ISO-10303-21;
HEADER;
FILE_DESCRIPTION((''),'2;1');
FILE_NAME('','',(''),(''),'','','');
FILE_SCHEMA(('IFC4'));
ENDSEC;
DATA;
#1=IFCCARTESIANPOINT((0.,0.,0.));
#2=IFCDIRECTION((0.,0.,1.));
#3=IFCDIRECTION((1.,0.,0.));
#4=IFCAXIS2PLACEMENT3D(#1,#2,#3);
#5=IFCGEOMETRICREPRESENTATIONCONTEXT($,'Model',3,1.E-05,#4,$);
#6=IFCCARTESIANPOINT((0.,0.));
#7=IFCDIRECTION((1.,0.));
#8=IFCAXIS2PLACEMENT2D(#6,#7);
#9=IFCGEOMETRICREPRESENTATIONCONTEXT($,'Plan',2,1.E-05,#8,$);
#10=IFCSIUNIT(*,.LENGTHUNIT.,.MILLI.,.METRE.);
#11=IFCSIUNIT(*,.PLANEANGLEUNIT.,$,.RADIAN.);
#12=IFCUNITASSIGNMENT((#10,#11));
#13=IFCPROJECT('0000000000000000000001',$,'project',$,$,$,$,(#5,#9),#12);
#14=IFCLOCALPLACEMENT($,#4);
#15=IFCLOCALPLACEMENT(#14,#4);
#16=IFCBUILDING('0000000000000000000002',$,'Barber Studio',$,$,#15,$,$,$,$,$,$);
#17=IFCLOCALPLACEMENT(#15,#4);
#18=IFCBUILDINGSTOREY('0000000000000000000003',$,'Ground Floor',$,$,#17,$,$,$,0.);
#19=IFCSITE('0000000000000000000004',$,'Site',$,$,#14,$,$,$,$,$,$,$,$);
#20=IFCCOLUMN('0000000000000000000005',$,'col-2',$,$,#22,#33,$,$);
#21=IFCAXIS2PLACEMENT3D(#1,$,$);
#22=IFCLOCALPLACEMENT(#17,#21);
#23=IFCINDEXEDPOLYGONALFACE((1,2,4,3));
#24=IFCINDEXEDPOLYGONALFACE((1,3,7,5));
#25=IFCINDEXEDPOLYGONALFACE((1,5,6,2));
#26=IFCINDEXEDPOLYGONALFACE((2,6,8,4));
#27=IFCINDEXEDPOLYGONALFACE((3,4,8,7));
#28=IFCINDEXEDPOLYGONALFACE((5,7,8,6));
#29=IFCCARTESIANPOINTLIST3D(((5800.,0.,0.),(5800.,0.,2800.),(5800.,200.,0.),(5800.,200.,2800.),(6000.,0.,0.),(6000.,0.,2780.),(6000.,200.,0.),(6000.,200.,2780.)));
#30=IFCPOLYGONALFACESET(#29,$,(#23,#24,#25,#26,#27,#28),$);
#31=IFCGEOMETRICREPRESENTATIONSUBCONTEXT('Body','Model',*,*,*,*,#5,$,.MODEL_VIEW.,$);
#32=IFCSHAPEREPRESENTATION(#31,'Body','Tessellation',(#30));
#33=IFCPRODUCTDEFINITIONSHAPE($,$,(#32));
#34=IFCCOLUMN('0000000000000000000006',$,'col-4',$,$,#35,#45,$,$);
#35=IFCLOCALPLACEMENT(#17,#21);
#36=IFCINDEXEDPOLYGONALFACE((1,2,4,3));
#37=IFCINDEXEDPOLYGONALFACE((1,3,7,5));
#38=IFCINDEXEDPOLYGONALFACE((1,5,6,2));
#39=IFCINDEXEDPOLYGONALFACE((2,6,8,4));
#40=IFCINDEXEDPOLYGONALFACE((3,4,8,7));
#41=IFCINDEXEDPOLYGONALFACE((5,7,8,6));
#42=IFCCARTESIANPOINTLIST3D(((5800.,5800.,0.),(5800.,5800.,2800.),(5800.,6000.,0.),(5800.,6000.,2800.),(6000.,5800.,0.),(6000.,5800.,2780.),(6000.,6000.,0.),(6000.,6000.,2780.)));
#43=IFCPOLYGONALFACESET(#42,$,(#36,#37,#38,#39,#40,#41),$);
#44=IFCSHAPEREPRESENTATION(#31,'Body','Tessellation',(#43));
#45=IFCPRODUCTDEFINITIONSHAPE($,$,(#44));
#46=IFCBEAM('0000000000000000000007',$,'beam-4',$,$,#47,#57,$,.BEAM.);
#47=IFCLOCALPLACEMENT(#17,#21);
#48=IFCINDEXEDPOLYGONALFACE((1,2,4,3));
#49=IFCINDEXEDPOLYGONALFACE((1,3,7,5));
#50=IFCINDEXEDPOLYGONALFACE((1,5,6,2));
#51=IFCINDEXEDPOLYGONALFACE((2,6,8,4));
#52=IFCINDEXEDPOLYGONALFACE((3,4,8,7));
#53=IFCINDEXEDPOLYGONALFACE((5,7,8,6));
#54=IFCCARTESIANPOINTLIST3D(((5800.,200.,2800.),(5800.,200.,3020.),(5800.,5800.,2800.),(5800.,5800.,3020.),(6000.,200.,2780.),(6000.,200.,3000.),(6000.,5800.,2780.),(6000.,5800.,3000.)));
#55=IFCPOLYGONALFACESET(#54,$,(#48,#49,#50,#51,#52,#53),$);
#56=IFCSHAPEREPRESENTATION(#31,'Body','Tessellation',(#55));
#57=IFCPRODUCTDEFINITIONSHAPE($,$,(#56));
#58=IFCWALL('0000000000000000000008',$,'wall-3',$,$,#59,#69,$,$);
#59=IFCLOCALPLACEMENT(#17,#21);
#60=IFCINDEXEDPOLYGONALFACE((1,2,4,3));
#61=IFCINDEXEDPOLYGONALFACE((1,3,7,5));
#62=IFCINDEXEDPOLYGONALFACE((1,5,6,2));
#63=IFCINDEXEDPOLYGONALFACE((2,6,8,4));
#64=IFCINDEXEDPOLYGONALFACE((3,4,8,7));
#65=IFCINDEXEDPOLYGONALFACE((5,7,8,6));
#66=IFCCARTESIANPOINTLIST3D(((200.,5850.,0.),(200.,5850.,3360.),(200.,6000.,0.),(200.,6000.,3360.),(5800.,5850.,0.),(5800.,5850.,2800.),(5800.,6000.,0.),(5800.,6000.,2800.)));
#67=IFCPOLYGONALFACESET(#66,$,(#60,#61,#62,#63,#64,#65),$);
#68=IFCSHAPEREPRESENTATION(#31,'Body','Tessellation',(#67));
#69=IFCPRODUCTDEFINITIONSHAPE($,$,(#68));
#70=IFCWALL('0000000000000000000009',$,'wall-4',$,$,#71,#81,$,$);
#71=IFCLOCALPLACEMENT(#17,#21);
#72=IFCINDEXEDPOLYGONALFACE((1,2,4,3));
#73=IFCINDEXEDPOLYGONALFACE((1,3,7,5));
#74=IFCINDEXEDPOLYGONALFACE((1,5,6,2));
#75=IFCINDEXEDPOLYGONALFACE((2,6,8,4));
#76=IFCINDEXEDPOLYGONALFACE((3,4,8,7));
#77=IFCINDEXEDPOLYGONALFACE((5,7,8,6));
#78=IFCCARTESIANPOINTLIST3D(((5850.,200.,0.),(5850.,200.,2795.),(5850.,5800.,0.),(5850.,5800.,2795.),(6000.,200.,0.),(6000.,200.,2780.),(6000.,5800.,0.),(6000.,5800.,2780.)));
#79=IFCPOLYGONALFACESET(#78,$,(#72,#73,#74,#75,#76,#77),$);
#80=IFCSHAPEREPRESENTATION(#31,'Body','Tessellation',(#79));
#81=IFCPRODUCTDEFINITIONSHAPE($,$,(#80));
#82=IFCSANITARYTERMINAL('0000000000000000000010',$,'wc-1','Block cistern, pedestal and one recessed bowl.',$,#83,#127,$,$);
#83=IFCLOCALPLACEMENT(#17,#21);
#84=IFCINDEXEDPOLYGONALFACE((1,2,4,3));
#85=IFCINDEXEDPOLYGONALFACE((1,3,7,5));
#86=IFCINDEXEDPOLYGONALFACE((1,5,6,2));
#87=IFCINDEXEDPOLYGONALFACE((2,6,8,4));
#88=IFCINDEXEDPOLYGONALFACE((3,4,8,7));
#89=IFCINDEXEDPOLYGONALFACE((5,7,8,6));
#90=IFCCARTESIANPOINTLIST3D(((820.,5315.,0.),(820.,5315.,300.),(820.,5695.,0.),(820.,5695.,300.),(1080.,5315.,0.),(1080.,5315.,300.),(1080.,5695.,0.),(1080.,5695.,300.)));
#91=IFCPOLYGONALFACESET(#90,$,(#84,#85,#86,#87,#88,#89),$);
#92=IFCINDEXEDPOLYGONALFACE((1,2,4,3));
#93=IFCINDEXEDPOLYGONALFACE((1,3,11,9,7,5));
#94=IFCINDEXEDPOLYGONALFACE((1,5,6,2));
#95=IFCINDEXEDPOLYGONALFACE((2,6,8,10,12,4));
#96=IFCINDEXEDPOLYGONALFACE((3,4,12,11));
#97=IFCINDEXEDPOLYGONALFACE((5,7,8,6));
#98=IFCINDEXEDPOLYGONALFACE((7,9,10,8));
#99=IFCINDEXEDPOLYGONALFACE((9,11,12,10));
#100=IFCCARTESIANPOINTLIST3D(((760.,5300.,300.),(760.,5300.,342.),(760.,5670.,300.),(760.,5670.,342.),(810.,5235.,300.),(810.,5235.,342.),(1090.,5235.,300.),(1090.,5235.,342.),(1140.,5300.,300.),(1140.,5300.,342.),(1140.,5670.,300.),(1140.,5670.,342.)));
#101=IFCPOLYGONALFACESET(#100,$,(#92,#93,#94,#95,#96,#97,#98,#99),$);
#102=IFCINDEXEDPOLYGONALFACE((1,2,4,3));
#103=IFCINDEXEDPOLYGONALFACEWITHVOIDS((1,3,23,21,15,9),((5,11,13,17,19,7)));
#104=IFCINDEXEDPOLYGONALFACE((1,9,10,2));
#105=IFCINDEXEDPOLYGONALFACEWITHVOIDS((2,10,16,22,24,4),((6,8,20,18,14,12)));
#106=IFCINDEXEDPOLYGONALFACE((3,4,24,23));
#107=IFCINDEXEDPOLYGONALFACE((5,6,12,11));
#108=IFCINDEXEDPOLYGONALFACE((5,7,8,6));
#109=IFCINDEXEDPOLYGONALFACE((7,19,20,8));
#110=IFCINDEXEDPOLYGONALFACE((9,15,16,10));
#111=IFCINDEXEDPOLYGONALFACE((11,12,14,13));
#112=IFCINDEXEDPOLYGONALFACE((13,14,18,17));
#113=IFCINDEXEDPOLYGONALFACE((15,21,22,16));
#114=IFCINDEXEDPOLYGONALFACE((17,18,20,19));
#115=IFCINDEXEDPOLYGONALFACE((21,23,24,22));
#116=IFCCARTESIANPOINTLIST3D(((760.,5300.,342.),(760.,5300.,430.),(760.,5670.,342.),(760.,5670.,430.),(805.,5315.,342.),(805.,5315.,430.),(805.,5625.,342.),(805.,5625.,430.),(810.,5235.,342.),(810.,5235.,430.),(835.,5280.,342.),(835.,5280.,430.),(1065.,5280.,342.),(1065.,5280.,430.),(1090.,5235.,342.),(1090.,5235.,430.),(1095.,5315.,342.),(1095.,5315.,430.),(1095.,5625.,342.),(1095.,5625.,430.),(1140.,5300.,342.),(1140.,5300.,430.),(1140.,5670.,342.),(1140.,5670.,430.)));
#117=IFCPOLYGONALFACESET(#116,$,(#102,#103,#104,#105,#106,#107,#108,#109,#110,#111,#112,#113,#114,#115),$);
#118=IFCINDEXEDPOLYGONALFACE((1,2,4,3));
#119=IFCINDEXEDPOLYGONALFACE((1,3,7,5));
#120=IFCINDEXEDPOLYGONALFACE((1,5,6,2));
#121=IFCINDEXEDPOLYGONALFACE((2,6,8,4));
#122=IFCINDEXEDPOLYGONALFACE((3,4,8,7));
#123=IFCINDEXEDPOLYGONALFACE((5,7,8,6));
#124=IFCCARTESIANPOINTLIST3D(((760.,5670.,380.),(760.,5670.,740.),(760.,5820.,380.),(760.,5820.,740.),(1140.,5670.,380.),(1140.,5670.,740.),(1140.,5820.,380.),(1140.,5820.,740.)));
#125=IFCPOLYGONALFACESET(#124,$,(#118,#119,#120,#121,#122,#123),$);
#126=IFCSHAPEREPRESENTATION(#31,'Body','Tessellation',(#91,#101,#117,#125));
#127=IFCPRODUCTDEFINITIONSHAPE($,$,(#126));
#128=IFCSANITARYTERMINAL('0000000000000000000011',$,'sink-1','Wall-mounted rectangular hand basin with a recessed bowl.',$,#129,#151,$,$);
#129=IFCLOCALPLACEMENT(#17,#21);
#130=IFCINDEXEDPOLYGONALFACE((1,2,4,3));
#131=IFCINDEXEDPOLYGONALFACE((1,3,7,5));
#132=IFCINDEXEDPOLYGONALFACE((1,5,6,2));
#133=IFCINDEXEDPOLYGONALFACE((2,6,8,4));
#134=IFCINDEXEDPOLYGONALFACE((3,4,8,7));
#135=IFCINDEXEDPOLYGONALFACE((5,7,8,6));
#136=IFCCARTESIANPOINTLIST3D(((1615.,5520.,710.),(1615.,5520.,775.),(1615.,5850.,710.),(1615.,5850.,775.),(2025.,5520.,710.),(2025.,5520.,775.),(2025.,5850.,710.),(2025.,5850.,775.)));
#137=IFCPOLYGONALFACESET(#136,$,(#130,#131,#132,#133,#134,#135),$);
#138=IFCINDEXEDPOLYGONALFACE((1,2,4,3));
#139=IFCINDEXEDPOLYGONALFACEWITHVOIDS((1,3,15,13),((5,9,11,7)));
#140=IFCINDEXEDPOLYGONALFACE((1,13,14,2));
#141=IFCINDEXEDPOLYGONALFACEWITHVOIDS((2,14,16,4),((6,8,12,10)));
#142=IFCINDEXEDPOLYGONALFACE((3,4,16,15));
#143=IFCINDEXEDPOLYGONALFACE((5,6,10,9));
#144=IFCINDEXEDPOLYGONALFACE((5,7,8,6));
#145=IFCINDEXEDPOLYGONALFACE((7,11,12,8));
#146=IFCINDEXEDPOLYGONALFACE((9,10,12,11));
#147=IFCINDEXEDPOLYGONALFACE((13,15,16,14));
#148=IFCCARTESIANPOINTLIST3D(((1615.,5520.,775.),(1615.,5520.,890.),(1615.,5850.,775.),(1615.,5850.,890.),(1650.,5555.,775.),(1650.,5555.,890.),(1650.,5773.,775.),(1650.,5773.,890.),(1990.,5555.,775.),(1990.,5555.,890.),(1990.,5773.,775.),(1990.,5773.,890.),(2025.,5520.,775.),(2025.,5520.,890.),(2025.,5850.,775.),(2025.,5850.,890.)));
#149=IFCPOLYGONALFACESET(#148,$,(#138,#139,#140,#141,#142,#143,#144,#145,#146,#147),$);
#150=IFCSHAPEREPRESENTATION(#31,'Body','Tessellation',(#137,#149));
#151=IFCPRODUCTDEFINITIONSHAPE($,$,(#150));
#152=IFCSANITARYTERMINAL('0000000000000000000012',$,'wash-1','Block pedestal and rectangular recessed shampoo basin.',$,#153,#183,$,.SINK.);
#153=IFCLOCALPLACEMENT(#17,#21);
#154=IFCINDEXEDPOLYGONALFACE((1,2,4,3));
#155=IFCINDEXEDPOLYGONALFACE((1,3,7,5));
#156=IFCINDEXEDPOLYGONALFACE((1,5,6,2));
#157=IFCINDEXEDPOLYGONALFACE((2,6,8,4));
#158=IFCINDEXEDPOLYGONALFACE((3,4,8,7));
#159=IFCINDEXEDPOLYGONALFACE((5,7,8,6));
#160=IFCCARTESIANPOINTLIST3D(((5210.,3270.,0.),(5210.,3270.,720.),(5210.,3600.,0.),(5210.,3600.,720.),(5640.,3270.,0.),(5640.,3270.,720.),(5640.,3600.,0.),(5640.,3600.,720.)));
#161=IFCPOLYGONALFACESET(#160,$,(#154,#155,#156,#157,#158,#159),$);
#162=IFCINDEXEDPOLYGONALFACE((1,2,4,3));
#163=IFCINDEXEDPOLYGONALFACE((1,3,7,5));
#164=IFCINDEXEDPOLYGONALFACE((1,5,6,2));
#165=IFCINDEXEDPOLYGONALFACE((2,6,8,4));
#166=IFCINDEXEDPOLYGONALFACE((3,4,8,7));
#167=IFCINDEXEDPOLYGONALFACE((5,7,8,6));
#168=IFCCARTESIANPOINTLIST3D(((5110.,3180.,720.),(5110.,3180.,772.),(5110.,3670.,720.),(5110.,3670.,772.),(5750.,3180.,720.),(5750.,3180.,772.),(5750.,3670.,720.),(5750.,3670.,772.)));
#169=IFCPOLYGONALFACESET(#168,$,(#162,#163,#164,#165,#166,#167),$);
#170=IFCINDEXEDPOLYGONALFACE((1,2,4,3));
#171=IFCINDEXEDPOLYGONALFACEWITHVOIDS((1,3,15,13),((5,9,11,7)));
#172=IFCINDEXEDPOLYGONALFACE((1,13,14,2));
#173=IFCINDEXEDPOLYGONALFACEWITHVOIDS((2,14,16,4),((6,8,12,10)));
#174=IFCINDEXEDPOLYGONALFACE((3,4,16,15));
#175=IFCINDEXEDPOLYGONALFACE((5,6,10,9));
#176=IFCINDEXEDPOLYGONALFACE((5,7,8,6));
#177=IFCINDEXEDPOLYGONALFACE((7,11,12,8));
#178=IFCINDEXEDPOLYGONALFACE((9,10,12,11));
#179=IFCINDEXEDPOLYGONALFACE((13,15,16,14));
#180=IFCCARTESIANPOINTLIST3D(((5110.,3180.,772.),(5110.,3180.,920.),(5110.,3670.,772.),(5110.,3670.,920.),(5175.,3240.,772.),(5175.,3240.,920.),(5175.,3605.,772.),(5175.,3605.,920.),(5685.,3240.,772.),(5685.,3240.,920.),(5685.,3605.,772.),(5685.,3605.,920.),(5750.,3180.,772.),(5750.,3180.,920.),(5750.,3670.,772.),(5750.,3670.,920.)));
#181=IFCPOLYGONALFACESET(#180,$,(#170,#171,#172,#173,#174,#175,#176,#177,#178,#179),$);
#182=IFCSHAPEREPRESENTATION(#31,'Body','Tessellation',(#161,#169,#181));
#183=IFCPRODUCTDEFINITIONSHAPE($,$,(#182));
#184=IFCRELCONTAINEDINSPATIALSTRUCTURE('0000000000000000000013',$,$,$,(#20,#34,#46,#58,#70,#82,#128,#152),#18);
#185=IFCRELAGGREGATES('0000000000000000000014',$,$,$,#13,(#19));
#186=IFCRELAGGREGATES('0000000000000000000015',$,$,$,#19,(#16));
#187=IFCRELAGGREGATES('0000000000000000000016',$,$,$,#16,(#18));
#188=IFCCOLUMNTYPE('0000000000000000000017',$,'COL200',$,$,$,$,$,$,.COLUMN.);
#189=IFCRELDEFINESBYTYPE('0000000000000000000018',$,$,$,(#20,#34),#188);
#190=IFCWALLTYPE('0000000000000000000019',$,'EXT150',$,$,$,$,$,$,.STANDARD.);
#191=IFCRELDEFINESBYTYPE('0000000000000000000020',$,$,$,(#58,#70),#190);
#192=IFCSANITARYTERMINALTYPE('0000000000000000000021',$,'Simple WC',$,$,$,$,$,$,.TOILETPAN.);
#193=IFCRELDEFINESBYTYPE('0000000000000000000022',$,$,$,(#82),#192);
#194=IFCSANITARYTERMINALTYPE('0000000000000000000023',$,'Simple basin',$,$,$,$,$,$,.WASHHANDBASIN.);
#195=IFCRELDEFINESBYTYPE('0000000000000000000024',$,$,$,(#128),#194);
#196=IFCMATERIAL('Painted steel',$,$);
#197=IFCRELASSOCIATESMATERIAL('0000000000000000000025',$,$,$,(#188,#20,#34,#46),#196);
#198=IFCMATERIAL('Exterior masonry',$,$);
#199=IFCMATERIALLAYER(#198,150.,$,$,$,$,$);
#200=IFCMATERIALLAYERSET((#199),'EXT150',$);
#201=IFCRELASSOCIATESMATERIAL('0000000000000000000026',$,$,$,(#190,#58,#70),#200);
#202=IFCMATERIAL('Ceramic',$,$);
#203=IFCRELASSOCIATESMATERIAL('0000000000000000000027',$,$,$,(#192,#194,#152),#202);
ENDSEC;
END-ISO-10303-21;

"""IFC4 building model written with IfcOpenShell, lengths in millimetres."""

from ifc_helpers import new_model, si_unit, frame, origin_with_axes, origin_2d_with_axis, place, context, subcontext, project, spatial, line, indexed_curve, rectangle, outline, extrude, clip, halfspace, material, layer, layer_set, layer_usage, material_profile, profile_set, profile_usage, type_object, element, save


model = new_model("IFC4")

# Units and contexts
model_context = context("Model", 3, precision=1e-05, world=origin_with_axes())
plan_context = context("Plan", 2, precision=1e-05, world=origin_2d_with_axis())
body_context_1 = subcontext(model_context, "Body", "Model", "MODEL_VIEW")
ifc_project = project(units=[si_unit("LENGTHUNIT", "METRE", prefix="MILLI"), si_unit("PLANEANGLEUNIT", "RADIAN")], contexts=[model_context, plan_context])

# Site, building, storey
site_placement = place(None, origin_with_axes())
site = spatial("IfcSite", under=ifc_project, at=site_placement, Name="Site")
building_placement = place(site_placement, origin_with_axes())
building = spatial("IfcBuilding", under=site, at=building_placement, Name="Barber Studio")
storey_placement = place(building_placement, origin_with_axes())
storey = spatial("IfcBuildingStorey", under=building, at=storey_placement, Name="Ground Floor", Elevation=0.0)

# Columns
ifc_material_1 = material(Name="Painted steel")
ifc_material_profile = material_profile(ifc_material_1, rectangle(XDim=200.0, YDim=200.0))
ifc_profile_set = profile_set([ifc_material_profile])
ifc_profile_usage_1 = profile_usage(ifc_profile_set, cardinal=5)
column_type = type_object("IfcColumnType", Name="COL200", PredefinedType="COLUMN", material=ifc_profile_set)
column_1_placement = place(storey_placement, frame((5900.0, 100.0, 0.0), z_axis=(0.0, 0.0, 1.0), x_axis=(1.0, 0.0, 0.0)))
element("IfcColumn", 1, at=column_1_placement, inside=storey, type_object=column_type, material=ifc_profile_usage_1, Name="col-2", context=body_context_1, shape_type="Clipping", body=[
    clip(extrude(rectangle(XDim=200.0, YDim=200.0), origin_with_axes(), (0.0, 0.0, 1.0), 3600.0), halfspace(frame((0.0, 0.0, 2790.0), z_axis=(0.1, 0.0, 1.0), x_axis=(0.0, -1.0, 0.0)), False)),
])
ifc_profile_usage_2 = profile_usage(ifc_profile_set, cardinal=5)
column_2_placement = place(storey_placement, frame((5900.0, 5900.0, 0.0), z_axis=(0.0, 0.0, 1.0), x_axis=(1.0, 0.0, 0.0)))
element("IfcColumn", 2, at=column_2_placement, inside=storey, type_object=column_type, material=ifc_profile_usage_2, Name="col-4", context=body_context_1, shape_type="Clipping", body=[
    clip(extrude(rectangle(XDim=200.0, YDim=200.0), origin_with_axes(), (0.0, 0.0, 1.0), 3600.0), halfspace(frame((0.0, 0.0, 2790.0), z_axis=(0.1, 0.0, 1.0), x_axis=(0.0, -1.0, 0.0)), False)),
])

# Beam
beam_placement = place(storey_placement, frame((5800.0, 200.0, 2800.0), z_axis=(0.0, 0.0, 1.0), x_axis=(1.0, 0.0, 0.0)))
element("IfcBeam", 3, at=beam_placement, inside=storey, material=ifc_material_1, Name="beam-4", PredefinedType="BEAM", context=body_context_1, shape_type="SweptSolid", body=[
    extrude(outline(indexed_curve([(0.0, 0.0), (200.0, -20.0), (200.0, 200.0), (0.0, 220.0)], segments=[line(1, 2, 3, 4, 1)])), frame((0.0, 0.0, 0.0), z_axis=(0.0, -1.0, 0.0), x_axis=(1.0, 0.0, 0.0)), (0.0, 0.0, -1.0), 5600.0),
])

# Walls
ifc_material_2 = material(Name="Exterior masonry")
ifc_layer_1 = layer(ifc_material_2, 150.0)
ifc_layer_set_1 = layer_set([ifc_layer_1], Name="EXT150")
ifc_layer_usage_1 = layer_usage(ifc_layer_set_1, "AXIS2", "POSITIVE", 0.0)
wall_type_1 = type_object("IfcWallType", Name="EXT150", PredefinedType="STANDARD", material=ifc_layer_set_1)
wall_1_placement = place(storey_placement, frame((5800.0, 6000.0, 0.0), z_axis=(0.0, 0.0, 1.0), x_axis=(-1.0, 0.0, 0.0)))
element("IfcWall", 4, at=wall_1_placement, inside=storey, type_object=wall_type_1, material=ifc_layer_usage_1, Name="wall-3", context=body_context_1, shape_type="Clipping", body=[
    clip(extrude(outline(indexed_curve([(0.0, 0.0), (0.0, 150.0), (5600.0, 150.0), (5600.0, 0.0), (0.0, 0.0)], self_intersect=False)), origin_with_axes(), (0.0, 0.0, 1.0), 3600.0), halfspace(frame((0.0, 0.0, 2800.0), z_axis=(-0.1, 0.0, 1.0), x_axis=(0.0, 1.0, 0.0)), False)),
])
ifc_layer_usage_2 = layer_usage(ifc_layer_set_1, "AXIS2", "POSITIVE", 0.0)
wall_2_placement = place(storey_placement, frame((6000.0, 200.0, 0.0), z_axis=(0.0, 0.0, 1.0), x_axis=(0.0, 1.0, 0.0)))
element("IfcWall", 5, at=wall_2_placement, inside=storey, type_object=wall_type_1, material=ifc_layer_usage_2, Name="wall-4", context=body_context_1, shape_type="Clipping", body=[
    clip(extrude(outline(indexed_curve([(0.0, 0.0), (0.0, 150.0), (5600.0, 150.0), (5600.0, 0.0), (0.0, 0.0)], self_intersect=False)), origin_with_axes(), (0.0, 0.0, 1.0), 3600.0), halfspace(frame((0.0, 0.0, 2780.0), z_axis=(0.0, -0.1, 1.0), x_axis=(-1.0, 0.0, 0.0)), False)),
])

# Sanitary terminals
ifc_material_3 = material(Name="Ceramic")
sanitary_terminal_type_1 = type_object("IfcSanitaryTerminalType", Name="Simple WC", PredefinedType="TOILETPAN", material=ifc_material_3)
sanitary_terminal_1_placement = place(storey_placement, frame((950.0, 5820.0, 0.0), z_axis=(0.0, 0.0, 1.0), x_axis=(1.0, 0.0, 0.0)))
element("IfcSanitaryTerminal", 6, at=sanitary_terminal_1_placement, inside=storey, type_object=sanitary_terminal_type_1, Name="wc-1", Description="Block cistern, pedestal and one recessed bowl.", context=body_context_1, shape_type="SweptSolid", body=[
    extrude(outline(indexed_curve([(0.0, 0.0), (260.0, 0.0), (260.0, 380.0), (0.0, 380.0)], segments=[line(1, 2, 3, 4, 1)])), frame((-130.0, -505.0, 0.0), z_axis=(0.0, 0.0, 1.0), x_axis=(1.0, 0.0, 0.0)), (0.0, 0.0, 1.0), 300.0),
    extrude(outline(indexed_curve([(-190.0, -150.0), (-190.0, -520.0), (-140.0, -585.0), (140.0, -585.0), (190.0, -520.0), (190.0, -150.0)], segments=[line(1, 2, 3, 4, 5, 6, 1)])), frame((0.0, 0.0, 300.0), z_axis=(0.0, 0.0, 1.0), x_axis=(1.0, 0.0, 0.0)), (0.0, 0.0, 1.0), 42.0),
    extrude(outline(indexed_curve([(-190.0, -150.0), (-190.0, -520.0), (-140.0, -585.0), (140.0, -585.0), (190.0, -520.0), (190.0, -150.0)], segments=[line(1, 2, 3, 4, 5, 6, 1)]), holes=[indexed_curve([(-145.0, -195.0), (-145.0, -505.0), (-115.0, -540.0), (115.0, -540.0), (145.0, -505.0), (145.0, -195.0)], segments=[line(1, 2, 3, 4, 5, 6, 1)])]), frame((0.0, 0.0, 342.0), z_axis=(0.0, 0.0, 1.0), x_axis=(1.0, 0.0, 0.0)), (0.0, 0.0, 1.0), 88.0),
    extrude(outline(indexed_curve([(0.0, 0.0), (380.0, 0.0), (380.0, 150.0), (0.0, 150.0)], segments=[line(1, 2, 3, 4, 1)])), frame((-190.0, -150.0, 380.0), z_axis=(0.0, 0.0, 1.0), x_axis=(1.0, 0.0, 0.0)), (0.0, 0.0, 1.0), 360.0),
])
sanitary_terminal_type_2 = type_object("IfcSanitaryTerminalType", Name="Simple basin", PredefinedType="WASHHANDBASIN", material=ifc_material_3)
sanitary_terminal_2_placement = place(storey_placement, frame((1820.0, 5850.0, 640.0), z_axis=(0.0, 0.0, 1.0), x_axis=(1.0, 0.0, 0.0)))
element("IfcSanitaryTerminal", 7, at=sanitary_terminal_2_placement, inside=storey, type_object=sanitary_terminal_type_2, Name="sink-1", Description="Wall-mounted rectangular hand basin with a recessed bowl.", context=body_context_1, shape_type="SweptSolid", body=[
    extrude(outline(indexed_curve([(0.0, 0.0), (410.0, 0.0), (410.0, 330.0), (0.0, 330.0)], segments=[line(1, 2, 3, 4, 1)])), frame((-205.0, -330.0, 70.0), z_axis=(0.0, 0.0, 1.0), x_axis=(1.0, 0.0, 0.0)), (0.0, 0.0, 1.0), 65.0),
    extrude(outline(indexed_curve([(-205.0, -330.0), (205.0, -330.0), (205.0, 0.0), (-205.0, 0.0)], segments=[line(1, 2, 3, 4, 1)]), holes=[indexed_curve([(-170.0, -295.0), (170.0, -295.0), (170.0, -77.0), (-170.0, -77.0)], segments=[line(1, 2, 3, 4, 1)])]), frame((0.0, 0.0, 135.0), z_axis=(0.0, 0.0, 1.0), x_axis=(1.0, 0.0, 0.0)), (0.0, 0.0, 1.0), 115.0),
])
sanitary_terminal_3_placement = place(storey_placement, frame((5110.0, 3180.0, 0.0), z_axis=(0.0, 0.0, 1.0), x_axis=(1.0, 0.0, 0.0)))
element("IfcSanitaryTerminal", 8, at=sanitary_terminal_3_placement, inside=storey, material=ifc_material_3, Name="wash-1", Description="Block pedestal and rectangular recessed shampoo basin.", PredefinedType="SINK", context=body_context_1, shape_type="SweptSolid", body=[
    extrude(outline(indexed_curve([(0.0, 0.0), (430.0, 0.0), (430.0, 330.0), (0.0, 330.0)], segments=[line(1, 2, 3, 4, 1)])), frame((100.0, 90.0, 0.0), z_axis=(0.0, 0.0, 1.0), x_axis=(1.0, 0.0, 0.0)), (0.0, 0.0, 1.0), 720.0),
    extrude(outline(indexed_curve([(0.0, 0.0), (640.0, 0.0), (640.0, 490.0), (0.0, 490.0)], segments=[line(1, 2, 3, 4, 1)])), frame((0.0, 0.0, 720.0), z_axis=(0.0, 0.0, 1.0), x_axis=(1.0, 0.0, 0.0)), (0.0, 0.0, 1.0), 52.0),
    extrude(outline(indexed_curve([(0.0, 0.0), (640.0, 0.0), (640.0, 490.0), (0.0, 490.0)], segments=[line(1, 2, 3, 4, 1)]), holes=[indexed_curve([(65.0, 60.0), (575.0, 60.0), (575.0, 425.0), (65.0, 425.0)], segments=[line(1, 2, 3, 4, 1)])]), frame((0.0, 0.0, 772.0), z_axis=(0.0, 0.0, 1.0), x_axis=(1.0, 0.0, 0.0)), (0.0, 0.0, 1.0), 148.0),
])

save(model, "model.ifc")
